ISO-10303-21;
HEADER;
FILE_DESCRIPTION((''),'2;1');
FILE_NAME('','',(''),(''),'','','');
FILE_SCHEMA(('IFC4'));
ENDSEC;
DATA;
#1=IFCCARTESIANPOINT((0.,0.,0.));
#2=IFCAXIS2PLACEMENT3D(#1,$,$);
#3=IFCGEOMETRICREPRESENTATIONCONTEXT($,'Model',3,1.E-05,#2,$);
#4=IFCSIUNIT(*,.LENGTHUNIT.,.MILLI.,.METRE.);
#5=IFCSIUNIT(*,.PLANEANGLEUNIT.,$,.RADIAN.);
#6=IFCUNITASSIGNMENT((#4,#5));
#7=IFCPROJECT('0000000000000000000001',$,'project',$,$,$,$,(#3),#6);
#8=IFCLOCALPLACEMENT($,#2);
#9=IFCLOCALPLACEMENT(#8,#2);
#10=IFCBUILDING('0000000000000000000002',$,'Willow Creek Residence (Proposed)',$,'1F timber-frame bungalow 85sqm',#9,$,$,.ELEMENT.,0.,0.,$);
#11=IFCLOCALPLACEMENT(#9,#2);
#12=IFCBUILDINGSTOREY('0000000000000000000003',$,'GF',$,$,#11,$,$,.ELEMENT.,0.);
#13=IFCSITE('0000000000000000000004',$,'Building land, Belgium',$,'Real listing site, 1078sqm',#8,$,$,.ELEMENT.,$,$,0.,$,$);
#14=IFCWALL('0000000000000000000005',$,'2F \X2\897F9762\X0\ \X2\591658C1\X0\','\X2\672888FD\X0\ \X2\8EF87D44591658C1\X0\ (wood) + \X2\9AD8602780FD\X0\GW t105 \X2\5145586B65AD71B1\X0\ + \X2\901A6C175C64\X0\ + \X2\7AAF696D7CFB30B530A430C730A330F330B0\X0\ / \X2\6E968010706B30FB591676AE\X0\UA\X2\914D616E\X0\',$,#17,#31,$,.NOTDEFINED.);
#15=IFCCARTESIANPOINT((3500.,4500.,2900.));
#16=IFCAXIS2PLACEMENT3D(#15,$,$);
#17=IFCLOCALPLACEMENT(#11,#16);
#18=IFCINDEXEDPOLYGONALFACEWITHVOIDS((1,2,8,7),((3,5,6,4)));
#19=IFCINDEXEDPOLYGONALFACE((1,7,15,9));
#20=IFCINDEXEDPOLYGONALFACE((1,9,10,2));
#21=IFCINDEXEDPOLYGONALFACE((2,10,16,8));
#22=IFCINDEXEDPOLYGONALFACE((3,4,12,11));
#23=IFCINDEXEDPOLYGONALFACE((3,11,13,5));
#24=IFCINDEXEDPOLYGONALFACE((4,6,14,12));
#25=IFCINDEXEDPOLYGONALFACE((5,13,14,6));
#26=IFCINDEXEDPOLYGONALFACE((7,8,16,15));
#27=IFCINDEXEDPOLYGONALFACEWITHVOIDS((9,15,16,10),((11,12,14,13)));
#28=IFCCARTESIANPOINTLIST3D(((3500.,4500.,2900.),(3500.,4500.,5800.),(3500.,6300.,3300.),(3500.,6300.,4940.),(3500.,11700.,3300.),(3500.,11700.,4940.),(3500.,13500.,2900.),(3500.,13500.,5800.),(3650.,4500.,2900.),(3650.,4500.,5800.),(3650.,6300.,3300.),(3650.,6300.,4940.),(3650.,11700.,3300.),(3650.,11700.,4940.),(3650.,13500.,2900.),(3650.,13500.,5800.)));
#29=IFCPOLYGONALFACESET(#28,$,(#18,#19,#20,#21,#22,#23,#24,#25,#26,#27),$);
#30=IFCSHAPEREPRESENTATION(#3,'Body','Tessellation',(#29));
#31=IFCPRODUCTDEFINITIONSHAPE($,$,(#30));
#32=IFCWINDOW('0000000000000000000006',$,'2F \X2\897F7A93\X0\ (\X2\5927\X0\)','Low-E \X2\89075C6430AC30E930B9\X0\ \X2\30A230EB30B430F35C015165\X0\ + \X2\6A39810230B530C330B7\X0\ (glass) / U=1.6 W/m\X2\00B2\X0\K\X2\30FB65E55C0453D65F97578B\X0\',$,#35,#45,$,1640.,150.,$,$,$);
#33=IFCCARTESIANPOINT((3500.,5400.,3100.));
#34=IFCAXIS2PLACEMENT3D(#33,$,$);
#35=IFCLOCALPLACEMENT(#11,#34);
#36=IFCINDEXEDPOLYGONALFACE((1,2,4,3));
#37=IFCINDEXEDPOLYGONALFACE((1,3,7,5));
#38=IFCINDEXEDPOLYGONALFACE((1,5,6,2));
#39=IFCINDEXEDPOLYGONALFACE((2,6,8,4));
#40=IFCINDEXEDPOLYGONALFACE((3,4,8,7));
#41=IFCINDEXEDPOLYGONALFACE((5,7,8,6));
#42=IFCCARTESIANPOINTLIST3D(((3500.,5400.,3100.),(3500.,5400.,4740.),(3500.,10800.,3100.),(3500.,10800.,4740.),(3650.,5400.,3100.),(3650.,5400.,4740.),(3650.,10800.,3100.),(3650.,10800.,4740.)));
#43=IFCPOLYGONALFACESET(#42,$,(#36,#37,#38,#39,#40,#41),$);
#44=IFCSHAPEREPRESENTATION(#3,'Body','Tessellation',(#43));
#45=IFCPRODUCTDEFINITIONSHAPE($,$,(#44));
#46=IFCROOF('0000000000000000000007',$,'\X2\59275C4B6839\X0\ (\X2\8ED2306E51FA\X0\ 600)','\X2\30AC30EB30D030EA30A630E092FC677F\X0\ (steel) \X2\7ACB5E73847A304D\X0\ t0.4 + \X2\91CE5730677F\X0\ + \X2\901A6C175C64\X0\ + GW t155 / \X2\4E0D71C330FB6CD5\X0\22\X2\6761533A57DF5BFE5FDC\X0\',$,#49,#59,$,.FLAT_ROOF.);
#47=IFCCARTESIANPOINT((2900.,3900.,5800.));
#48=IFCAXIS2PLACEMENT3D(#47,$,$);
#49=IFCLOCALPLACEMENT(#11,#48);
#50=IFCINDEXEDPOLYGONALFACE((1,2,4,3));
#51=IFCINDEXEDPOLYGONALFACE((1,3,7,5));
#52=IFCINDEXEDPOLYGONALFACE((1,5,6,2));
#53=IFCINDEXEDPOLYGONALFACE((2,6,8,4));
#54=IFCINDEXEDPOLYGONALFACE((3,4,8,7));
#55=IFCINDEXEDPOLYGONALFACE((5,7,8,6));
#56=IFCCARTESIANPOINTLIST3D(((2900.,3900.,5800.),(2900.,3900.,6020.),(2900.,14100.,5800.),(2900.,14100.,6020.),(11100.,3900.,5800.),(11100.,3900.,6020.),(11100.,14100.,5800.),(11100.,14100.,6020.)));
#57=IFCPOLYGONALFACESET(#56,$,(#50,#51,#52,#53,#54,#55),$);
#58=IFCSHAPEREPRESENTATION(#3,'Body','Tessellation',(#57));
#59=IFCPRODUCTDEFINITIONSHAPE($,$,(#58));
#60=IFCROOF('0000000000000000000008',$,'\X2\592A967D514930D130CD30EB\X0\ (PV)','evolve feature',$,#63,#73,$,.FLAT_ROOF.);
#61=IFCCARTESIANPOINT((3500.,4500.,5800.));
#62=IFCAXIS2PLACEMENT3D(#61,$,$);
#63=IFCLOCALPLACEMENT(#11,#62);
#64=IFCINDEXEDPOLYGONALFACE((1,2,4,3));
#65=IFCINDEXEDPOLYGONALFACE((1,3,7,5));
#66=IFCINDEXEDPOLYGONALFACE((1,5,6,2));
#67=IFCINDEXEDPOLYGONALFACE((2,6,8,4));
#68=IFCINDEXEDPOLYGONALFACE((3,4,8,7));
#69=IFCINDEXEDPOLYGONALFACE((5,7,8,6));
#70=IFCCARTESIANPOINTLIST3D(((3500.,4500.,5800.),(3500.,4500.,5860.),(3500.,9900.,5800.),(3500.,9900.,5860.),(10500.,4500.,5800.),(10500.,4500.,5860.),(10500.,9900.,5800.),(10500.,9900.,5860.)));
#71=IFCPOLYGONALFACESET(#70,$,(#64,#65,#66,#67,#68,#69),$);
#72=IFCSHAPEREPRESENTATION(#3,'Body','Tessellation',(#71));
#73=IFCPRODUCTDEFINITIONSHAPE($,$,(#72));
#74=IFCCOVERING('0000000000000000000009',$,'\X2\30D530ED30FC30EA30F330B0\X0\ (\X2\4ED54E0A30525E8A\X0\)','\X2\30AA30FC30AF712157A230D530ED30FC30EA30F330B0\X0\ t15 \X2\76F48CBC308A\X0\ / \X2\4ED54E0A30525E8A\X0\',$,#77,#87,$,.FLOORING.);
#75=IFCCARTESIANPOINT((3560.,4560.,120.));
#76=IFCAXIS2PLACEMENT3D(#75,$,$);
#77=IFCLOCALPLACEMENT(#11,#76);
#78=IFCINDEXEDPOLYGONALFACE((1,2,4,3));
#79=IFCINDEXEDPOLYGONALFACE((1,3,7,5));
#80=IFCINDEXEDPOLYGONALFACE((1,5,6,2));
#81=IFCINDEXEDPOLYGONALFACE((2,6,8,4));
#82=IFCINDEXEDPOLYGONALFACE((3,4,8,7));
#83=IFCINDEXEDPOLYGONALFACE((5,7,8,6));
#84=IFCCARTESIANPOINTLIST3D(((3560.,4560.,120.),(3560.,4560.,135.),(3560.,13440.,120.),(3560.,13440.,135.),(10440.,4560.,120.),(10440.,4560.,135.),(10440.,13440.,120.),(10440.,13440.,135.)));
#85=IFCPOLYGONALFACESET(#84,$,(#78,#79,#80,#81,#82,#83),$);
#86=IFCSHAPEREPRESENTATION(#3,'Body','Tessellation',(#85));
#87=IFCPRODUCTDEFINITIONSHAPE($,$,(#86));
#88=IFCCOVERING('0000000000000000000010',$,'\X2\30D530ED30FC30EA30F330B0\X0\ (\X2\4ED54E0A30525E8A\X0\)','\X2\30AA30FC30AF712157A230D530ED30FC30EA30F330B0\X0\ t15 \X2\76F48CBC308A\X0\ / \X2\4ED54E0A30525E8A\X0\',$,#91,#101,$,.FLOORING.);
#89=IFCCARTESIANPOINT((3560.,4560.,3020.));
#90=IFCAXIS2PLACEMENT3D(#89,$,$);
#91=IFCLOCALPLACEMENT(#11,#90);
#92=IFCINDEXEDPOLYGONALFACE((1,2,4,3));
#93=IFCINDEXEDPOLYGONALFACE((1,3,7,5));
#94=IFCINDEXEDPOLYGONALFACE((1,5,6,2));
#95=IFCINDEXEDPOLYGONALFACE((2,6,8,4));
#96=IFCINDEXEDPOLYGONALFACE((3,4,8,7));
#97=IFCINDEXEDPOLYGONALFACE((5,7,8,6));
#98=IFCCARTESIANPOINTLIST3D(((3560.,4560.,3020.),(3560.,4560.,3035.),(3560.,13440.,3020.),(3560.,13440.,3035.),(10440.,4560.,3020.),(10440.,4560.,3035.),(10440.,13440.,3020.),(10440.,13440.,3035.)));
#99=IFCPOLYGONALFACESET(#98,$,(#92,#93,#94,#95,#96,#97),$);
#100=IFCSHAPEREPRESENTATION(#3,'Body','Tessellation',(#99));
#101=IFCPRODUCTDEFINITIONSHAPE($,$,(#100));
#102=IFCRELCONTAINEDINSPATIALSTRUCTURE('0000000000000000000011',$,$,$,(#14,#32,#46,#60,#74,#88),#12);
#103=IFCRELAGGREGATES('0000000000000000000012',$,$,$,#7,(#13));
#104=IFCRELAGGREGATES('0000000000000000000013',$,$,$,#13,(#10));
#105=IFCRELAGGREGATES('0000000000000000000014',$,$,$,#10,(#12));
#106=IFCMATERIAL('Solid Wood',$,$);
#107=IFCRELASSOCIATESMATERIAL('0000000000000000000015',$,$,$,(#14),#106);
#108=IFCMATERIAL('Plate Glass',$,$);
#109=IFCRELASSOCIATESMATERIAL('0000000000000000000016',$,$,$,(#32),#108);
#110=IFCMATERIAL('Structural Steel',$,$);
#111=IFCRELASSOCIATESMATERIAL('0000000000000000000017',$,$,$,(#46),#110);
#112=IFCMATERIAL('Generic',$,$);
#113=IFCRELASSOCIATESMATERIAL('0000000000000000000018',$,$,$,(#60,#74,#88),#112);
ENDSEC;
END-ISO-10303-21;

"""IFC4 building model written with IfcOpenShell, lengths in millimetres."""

from ifc_helpers import new_model, si_unit, frame, frame_2d, origin, place, context, project, spatial, rectangle, extrude, material, element, fill, save


model = new_model("IFC4")

# Units and contexts
model_context = context("Model", 3, precision=1e-05, world=origin())
ifc_project = project(units=[si_unit("LENGTHUNIT", "METRE", prefix="MILLI"), si_unit("PLANEANGLEUNIT", "RADIAN")], contexts=[model_context])

# Site, building, storey
site_placement = place(None, origin())
site = spatial("IfcSite", under=ifc_project, at=site_placement, Name="Building land, Belgium", ObjectType="Real listing site, 1078sqm", CompositionType="ELEMENT", RefElevation=0.0)
building_placement = place(site_placement, origin())
building = spatial("IfcBuilding", under=site, at=building_placement, Name="Willow Creek Residence (Proposed)", ObjectType="1F timber-frame bungalow 85sqm", CompositionType="ELEMENT", ElevationOfRefHeight=0.0, ElevationOfTerrain=0.0)
storey_placement = place(building_placement, origin())
storey = spatial("IfcBuildingStorey", under=building, at=storey_placement, Name="GF", CompositionType="ELEMENT", Elevation=0.0)

# Shared definitions
ifc_material_1 = material(Name="Solid Wood")
ifc_material_2 = material(Name="Generic")

# Shared definitions
ifc_material_3 = material(Name="Plate Glass")

# Wall, opening, window
wall_1_placement = place(storey_placement, frame((3500.0, 4500.0, 2900.0)))
wall_1 = element("IfcWall", 1, at=wall_1_placement, inside=storey, material=ifc_material_1, Name="2F 西面 外壁", Description="木製 軸組外壁 (wood) + 高性能GW t105 充填断熱 + 通気層 + 窯業系サイディング / 準耐火・外皮UA配慮", PredefinedType="NOTDEFINED", context=model_context, shape_type="SweptSolid", body=[
    extrude(rectangle(XDim=150.0, YDim=9000.0, at=frame_2d((75.0, 4500.0))), frame((3500.0, 4500.0, 2900.0)), (0.0, 0.0, 1.0), 2900.0),
])
opening_1_placement = place(storey_placement, frame((3500.0, 5400.0, 3100.0)))
opening_1 = element("IfcOpeningElement", 2, at=opening_1_placement, cuts=wall_1, PredefinedType="NOTDEFINED", context=model_context, shape_type="SweptSolid", body=[
    extrude(rectangle(XDim=150.0, YDim=5400.0, at=frame_2d((75.0, 2700.0))), frame((3500.0, 5400.0, 3100.0)), (0.0, 0.0, 1.0), 1640.0),
])
window_1_placement = place(storey_placement, frame((3500.0, 5400.0, 3100.0)))
window_1 = element("IfcWindow", 3, at=window_1_placement, inside=storey, material=ifc_material_3, Name="2F 西窓 (大)", Description="Low-E 複層ガラス アルゴン封入 + 樹脂サッシ (glass) / U=1.6 W/m²K・日射取得型", OverallHeight=1640.0, OverallWidth=150.0, context=model_context, shape_type="SweptSolid", body=[
    extrude(rectangle(XDim=150.0, YDim=5400.0, at=frame_2d((75.0, 2700.0))), frame((3500.0, 5400.0, 3100.0)), (0.0, 0.0, 1.0), 1640.0),
])
fill(opening_1, window_1)

# Roofs
ifc_material_4 = material(Name="Structural Steel")
roof_1_placement = place(storey_placement, frame((2900.0, 3900.0, 5800.0)))
element("IfcRoof", 4, at=roof_1_placement, inside=storey, material=ifc_material_4, Name="大屋根 (軒の出 600)", Description="ガルバリウム鋼板 (steel) 立平葺き t0.4 + 野地板 + 通気層 + GW t155 / 不燃・法22条区域対応", PredefinedType="FLAT_ROOF", context=model_context, shape_type="SweptSolid", body=[
    extrude(rectangle(XDim=8200.0, YDim=10200.0, at=frame_2d((4100.0, 5100.0))), frame((2900.0, 3900.0, 5800.0)), (0.0, 0.0, 1.0), 220.0),
])
roof_2_placement = place(storey_placement, frame((3500.0, 4500.0, 5800.0)))
element("IfcRoof", 5, at=roof_2_placement, inside=storey, material=ifc_material_2, Name="太陽光パネル (PV)", Description="evolve feature", PredefinedType="FLAT_ROOF", context=model_context, shape_type="SweptSolid", body=[
    extrude(rectangle(XDim=7000.0, YDim=5400.0, at=frame_2d((3500.0, 2700.0))), frame((3500.0, 4500.0, 5800.0)), (0.0, 0.0, 1.0), 60.0),
])

# Coverings
covering_1_placement = place(storey_placement, frame((3560.0, 4560.0, 120.0)))
element("IfcCovering", 6, at=covering_1_placement, inside=storey, material=ifc_material_2, Name="フローリング (仕上げ床)", Description="オーク無垢フローリング t15 直貼り / 仕上げ床", PredefinedType="FLOORING", context=model_context, shape_type="SweptSolid", body=[
    extrude(rectangle(XDim=6880.0, YDim=8880.0, at=frame_2d((3440.0, 4440.0))), frame((3560.0, 4560.0, 120.0)), (0.0, 0.0, 1.0), 15.0),
])
covering_2_placement = place(storey_placement, frame((3560.0, 4560.0, 3020.0)))
element("IfcCovering", 7, at=covering_2_placement, inside=storey, material=ifc_material_2, Name="フローリング (仕上げ床)", Description="オーク無垢フローリング t15 直貼り / 仕上げ床", PredefinedType="FLOORING", context=model_context, shape_type="SweptSolid", body=[
    extrude(rectangle(XDim=6880.0, YDim=8880.0, at=frame_2d((3440.0, 4440.0))), frame((3560.0, 4560.0, 3020.0)), (0.0, 0.0, 1.0), 15.0),
])

save(model, "model.ifc")
